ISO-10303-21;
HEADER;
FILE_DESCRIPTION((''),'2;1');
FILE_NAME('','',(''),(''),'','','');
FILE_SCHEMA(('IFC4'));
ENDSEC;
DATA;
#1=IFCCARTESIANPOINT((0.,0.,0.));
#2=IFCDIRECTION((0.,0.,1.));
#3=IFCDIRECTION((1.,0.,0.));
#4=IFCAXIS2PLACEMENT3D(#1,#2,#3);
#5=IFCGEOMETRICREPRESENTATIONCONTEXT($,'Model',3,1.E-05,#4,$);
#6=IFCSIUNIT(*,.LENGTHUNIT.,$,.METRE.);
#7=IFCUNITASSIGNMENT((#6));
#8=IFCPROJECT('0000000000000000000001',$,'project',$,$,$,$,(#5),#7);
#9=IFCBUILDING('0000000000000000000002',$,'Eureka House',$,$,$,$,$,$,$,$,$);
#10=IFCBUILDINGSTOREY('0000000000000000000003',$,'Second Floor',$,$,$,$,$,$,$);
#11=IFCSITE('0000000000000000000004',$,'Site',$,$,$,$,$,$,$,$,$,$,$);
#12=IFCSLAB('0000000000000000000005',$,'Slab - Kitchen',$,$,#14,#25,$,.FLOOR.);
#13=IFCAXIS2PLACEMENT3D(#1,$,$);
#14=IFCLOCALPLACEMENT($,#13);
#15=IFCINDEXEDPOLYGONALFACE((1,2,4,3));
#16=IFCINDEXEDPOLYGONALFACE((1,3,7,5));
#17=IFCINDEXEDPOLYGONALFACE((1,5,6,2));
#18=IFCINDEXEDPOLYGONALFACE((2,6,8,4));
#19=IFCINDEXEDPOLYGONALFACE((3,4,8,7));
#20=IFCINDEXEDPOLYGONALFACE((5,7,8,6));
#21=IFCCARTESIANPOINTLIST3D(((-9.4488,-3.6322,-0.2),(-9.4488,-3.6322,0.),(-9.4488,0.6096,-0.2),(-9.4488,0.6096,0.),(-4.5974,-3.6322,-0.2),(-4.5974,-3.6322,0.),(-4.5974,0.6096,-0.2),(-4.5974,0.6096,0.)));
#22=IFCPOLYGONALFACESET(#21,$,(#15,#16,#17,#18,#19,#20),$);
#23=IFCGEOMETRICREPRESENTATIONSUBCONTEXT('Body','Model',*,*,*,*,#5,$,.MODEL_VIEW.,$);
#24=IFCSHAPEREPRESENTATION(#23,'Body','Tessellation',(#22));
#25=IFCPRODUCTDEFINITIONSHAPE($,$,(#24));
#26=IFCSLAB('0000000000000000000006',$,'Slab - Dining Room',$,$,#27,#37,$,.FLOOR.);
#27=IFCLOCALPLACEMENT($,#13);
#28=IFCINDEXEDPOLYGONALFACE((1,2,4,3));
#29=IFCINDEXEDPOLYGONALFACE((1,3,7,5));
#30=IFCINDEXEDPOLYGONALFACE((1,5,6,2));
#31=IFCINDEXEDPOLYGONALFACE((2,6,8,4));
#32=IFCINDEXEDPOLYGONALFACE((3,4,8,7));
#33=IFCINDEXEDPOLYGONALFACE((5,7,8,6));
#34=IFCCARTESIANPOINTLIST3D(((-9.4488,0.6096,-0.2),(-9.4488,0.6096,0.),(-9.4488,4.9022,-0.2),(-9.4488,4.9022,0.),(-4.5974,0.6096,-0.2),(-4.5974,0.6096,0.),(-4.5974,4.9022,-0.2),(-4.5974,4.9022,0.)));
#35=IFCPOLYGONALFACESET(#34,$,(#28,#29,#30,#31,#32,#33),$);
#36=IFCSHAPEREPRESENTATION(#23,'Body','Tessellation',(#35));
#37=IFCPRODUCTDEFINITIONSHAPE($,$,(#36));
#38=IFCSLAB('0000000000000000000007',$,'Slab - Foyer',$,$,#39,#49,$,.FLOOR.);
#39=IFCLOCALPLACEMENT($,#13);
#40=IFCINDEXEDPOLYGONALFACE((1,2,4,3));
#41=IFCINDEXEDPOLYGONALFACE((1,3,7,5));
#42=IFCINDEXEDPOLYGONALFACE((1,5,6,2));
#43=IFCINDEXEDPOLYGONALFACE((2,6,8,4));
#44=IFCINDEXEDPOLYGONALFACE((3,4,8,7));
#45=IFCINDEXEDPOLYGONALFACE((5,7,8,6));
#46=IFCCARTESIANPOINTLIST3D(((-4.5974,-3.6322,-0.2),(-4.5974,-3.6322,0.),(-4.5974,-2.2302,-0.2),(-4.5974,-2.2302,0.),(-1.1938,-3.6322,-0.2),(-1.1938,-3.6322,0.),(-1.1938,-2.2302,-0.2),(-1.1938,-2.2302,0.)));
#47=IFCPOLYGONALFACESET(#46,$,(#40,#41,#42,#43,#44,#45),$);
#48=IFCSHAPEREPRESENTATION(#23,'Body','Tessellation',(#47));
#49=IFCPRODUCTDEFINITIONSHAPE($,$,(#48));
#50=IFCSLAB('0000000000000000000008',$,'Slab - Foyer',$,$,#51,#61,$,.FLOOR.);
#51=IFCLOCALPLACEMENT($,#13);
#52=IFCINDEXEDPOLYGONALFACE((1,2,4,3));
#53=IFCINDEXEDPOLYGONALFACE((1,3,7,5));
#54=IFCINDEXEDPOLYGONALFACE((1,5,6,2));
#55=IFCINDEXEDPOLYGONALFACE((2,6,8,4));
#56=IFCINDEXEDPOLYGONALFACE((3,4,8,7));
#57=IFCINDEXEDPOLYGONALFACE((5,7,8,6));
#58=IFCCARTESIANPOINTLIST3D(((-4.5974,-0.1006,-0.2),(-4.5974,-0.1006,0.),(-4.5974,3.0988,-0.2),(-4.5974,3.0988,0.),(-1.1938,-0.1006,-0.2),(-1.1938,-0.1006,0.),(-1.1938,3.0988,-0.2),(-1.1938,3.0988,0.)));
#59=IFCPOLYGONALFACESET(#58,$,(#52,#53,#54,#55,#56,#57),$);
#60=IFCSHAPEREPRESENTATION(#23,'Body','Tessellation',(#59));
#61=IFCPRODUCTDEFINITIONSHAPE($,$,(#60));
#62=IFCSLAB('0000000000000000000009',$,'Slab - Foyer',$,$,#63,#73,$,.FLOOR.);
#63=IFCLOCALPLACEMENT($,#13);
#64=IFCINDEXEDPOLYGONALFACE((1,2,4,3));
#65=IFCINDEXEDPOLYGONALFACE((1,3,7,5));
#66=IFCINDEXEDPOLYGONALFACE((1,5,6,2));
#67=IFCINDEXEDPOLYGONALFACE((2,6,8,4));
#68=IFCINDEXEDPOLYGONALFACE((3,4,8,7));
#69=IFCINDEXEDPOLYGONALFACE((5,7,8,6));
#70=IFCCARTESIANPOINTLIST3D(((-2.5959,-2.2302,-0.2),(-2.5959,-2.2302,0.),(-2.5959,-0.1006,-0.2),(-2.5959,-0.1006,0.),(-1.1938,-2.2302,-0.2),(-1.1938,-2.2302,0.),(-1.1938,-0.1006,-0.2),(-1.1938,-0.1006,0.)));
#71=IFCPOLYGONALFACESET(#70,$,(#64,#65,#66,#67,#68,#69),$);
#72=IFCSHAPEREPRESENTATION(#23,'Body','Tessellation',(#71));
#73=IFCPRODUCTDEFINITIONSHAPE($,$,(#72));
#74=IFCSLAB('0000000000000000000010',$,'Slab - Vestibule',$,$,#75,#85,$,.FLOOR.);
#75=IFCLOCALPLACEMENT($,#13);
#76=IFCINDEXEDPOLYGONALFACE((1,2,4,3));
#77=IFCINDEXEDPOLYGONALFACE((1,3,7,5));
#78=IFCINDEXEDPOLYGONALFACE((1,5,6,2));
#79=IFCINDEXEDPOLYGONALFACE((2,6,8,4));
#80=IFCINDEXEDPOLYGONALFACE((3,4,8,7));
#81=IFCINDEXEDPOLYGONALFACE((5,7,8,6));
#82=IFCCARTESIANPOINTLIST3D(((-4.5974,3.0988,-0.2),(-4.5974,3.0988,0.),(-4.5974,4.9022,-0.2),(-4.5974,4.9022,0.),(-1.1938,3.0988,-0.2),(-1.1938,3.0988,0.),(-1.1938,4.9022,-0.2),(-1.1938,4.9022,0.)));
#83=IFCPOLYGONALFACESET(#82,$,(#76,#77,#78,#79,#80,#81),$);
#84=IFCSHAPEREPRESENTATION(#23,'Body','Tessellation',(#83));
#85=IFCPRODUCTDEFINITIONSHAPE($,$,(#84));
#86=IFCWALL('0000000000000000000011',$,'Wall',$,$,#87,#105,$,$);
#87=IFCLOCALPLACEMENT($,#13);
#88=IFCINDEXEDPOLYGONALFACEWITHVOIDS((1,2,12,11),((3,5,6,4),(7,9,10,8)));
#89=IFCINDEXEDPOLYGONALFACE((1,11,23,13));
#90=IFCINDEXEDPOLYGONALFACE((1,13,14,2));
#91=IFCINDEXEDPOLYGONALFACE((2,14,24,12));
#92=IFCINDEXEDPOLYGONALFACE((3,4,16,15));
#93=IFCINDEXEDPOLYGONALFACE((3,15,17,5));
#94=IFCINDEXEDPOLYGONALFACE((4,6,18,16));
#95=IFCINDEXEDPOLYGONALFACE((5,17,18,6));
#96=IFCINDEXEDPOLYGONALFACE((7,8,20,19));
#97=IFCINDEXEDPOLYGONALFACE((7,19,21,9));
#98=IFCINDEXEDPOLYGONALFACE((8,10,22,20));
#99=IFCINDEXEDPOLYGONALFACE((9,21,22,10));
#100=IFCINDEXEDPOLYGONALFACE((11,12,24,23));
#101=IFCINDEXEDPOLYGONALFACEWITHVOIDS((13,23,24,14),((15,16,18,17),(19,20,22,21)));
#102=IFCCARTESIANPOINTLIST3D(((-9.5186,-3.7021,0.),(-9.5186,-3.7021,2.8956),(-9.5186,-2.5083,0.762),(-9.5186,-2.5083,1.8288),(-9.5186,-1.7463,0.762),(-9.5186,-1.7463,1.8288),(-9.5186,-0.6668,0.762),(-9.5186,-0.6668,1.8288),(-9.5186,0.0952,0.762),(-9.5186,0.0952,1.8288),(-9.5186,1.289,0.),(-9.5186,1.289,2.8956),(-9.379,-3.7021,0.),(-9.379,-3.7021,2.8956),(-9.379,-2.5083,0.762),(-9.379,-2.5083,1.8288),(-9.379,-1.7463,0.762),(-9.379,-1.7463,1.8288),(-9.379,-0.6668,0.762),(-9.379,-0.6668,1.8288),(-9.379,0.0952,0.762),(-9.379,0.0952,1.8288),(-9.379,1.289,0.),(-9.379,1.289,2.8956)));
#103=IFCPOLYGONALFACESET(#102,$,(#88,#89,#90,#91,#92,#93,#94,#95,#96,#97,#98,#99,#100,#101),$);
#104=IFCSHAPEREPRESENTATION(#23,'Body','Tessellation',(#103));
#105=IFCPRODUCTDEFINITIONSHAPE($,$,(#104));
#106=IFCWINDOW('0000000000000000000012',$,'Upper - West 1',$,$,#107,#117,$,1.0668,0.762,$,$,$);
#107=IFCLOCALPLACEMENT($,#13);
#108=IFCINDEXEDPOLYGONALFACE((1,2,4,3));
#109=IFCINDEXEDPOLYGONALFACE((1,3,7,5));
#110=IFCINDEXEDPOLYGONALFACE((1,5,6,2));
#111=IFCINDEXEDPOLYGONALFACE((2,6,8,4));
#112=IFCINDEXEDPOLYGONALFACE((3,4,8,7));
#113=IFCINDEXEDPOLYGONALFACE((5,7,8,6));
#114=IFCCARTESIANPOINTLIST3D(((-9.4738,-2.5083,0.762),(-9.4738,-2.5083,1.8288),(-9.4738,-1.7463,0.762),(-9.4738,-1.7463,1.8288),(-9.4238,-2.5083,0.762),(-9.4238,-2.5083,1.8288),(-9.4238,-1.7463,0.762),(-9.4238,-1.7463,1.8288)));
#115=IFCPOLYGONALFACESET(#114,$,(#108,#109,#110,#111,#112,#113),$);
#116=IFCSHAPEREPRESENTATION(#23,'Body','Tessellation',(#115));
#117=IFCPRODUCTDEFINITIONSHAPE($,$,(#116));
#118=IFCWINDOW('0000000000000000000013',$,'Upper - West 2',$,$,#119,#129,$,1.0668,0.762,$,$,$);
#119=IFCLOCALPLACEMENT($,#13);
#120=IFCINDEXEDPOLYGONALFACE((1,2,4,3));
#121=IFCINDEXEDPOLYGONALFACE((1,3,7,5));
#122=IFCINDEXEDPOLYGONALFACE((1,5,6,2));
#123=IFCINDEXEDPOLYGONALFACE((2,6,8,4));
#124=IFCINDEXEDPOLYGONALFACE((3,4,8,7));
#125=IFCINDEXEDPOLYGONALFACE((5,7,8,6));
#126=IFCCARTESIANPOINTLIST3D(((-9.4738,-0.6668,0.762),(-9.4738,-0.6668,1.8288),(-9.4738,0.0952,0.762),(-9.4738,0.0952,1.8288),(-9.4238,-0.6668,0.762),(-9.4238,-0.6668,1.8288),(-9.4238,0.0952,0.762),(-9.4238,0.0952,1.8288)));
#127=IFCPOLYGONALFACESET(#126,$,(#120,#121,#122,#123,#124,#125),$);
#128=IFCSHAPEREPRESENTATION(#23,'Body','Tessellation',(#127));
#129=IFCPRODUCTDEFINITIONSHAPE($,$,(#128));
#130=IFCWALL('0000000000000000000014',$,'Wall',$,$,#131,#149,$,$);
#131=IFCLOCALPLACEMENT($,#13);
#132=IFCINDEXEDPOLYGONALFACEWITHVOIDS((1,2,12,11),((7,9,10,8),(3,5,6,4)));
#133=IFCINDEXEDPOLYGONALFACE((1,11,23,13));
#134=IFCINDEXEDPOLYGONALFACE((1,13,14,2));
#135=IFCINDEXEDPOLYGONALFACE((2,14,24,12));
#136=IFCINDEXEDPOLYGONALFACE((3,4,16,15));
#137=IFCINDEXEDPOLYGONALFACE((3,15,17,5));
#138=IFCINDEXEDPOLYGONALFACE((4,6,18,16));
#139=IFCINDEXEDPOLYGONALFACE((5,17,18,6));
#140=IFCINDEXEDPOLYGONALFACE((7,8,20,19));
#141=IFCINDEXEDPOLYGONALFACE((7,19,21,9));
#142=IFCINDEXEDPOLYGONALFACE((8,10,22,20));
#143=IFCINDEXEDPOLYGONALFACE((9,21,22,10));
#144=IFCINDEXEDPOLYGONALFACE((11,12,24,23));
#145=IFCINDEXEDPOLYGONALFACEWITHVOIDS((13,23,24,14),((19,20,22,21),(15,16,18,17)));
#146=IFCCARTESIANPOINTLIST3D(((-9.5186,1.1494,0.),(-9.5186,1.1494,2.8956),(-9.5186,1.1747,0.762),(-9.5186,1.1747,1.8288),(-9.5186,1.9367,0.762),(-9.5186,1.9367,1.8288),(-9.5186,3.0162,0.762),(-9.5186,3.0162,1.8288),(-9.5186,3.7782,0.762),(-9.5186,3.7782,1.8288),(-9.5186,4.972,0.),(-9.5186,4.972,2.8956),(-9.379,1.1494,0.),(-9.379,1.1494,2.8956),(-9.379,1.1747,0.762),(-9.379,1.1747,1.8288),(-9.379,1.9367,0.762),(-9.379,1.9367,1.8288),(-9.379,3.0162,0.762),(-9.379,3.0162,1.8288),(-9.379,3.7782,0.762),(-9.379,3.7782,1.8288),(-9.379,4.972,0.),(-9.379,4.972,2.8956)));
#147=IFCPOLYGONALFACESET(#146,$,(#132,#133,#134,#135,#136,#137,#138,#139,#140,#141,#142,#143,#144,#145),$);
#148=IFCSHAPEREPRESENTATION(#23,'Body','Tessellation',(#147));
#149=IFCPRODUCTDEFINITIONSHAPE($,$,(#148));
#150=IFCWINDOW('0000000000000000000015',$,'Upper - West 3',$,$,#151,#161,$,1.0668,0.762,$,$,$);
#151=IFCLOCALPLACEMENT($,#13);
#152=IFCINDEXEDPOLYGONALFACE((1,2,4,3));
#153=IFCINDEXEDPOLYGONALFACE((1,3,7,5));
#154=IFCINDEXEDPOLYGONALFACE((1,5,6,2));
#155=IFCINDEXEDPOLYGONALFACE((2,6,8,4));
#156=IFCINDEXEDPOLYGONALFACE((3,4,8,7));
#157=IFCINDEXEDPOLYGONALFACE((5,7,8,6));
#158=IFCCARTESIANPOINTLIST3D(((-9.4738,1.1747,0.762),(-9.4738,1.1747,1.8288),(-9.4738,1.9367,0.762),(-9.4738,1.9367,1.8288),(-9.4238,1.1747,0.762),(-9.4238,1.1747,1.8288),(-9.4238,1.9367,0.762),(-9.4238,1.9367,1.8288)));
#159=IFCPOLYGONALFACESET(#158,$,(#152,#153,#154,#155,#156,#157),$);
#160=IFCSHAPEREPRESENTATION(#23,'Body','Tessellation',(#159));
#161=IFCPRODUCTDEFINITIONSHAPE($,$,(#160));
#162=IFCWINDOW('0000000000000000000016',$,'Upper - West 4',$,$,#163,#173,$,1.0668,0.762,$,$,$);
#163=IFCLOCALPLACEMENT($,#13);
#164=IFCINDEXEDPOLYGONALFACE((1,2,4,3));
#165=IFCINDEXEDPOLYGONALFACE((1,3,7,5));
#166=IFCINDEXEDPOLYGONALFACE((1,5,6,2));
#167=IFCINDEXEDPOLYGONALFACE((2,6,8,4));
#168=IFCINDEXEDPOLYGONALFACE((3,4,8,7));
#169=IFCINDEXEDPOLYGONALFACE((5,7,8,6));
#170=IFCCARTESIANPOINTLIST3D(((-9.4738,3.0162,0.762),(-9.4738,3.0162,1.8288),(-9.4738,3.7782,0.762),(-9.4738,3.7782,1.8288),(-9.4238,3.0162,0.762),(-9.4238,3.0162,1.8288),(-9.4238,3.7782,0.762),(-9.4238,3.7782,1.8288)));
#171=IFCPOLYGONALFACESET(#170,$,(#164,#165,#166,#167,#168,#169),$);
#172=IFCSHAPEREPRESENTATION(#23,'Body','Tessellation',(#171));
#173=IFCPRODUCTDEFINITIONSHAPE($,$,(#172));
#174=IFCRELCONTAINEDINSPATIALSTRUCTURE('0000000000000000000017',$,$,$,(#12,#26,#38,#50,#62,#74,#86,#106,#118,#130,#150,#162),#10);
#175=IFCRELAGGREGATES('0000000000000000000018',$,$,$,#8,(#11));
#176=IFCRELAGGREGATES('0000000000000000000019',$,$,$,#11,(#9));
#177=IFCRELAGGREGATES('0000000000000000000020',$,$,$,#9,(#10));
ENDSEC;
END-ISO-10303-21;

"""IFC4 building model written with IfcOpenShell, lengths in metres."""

from ifc_helpers import new_model, si_unit, frame, origin, origin_with_axes, origin_2d, place, context, subcontext, project, spatial, rectangle, extrude, element, fill, save


model = new_model("IFC4")

# Units and contexts
model_context = context("Model", 3, precision=1e-05, world=origin_with_axes())
body_context = subcontext(model_context, "Body", "Model", "MODEL_VIEW")
ifc_project = project(units=[si_unit("LENGTHUNIT", "METRE")], contexts=[model_context])

# Site, building, storey
site = spatial("IfcSite", under=ifc_project, Name="Site")
building = spatial("IfcBuilding", under=site, Name="Eureka House")
storey = spatial("IfcBuildingStorey", under=building, Name="Second Floor")

# Slabs
slab_1_placement = place(None, frame((-7.0231, -1.5113, -0.2), z_axis=(0.0, 0.0, 1.0), x_axis=(1.0, 0.0, 0.0)))
element("IfcSlab", 1, at=slab_1_placement, inside=storey, Name="Slab - Kitchen", PredefinedType="FLOOR", context=body_context, shape_type="SweptSolid", body=[
    extrude(rectangle(XDim=4.8514, YDim=4.2418, at=origin_2d()), origin(), (0.0, 0.0, 1.0), 0.2),
])
slab_2_placement = place(None, frame((-7.0231, 2.7559, -0.2), z_axis=(0.0, 0.0, 1.0), x_axis=(1.0, 0.0, 0.0)))
element("IfcSlab", 2, at=slab_2_placement, inside=storey, Name="Slab - Dining Room", PredefinedType="FLOOR", context=body_context, shape_type="SweptSolid", body=[
    extrude(rectangle(XDim=4.8514, YDim=4.2926, at=origin_2d()), origin(), (0.0, 0.0, 1.0), 0.2),
])
slab_3_placement = place(None, frame((-2.8956, -2.9312, -0.2), z_axis=(0.0, 0.0, 1.0), x_axis=(1.0, 0.0, 0.0)))
element("IfcSlab", 3, at=slab_3_placement, inside=storey, Name="Slab - Foyer", PredefinedType="FLOOR", context=body_context, shape_type="SweptSolid", body=[
    extrude(rectangle(XDim=3.4036, YDim=1.402, at=origin_2d()), origin(), (0.0, 0.0, 1.0), 0.2),
])
slab_4_placement = place(None, frame((-2.8956, 1.4991, -0.2), z_axis=(0.0, 0.0, 1.0), x_axis=(1.0, 0.0, 0.0)))
element("IfcSlab", 4, at=slab_4_placement, inside=storey, Name="Slab - Foyer", PredefinedType="FLOOR", context=body_context, shape_type="SweptSolid", body=[
    extrude(rectangle(XDim=3.4036, YDim=3.1994, at=origin_2d()), origin(), (0.0, 0.0, 1.0), 0.2),
])
slab_5_placement = place(None, frame((-1.8949, -1.1654, -0.2), z_axis=(0.0, 0.0, 1.0), x_axis=(1.0, 0.0, 0.0)))
element("IfcSlab", 5, at=slab_5_placement, inside=storey, Name="Slab - Foyer", PredefinedType="FLOOR", context=body_context, shape_type="SweptSolid", body=[
    extrude(rectangle(XDim=1.4021, YDim=2.1296, at=origin_2d()), origin(), (0.0, 0.0, 1.0), 0.2),
])
slab_6_placement = place(None, frame((-2.8956, 4.0005, -0.2), z_axis=(0.0, 0.0, 1.0), x_axis=(1.0, 0.0, 0.0)))
element("IfcSlab", 6, at=slab_6_placement, inside=storey, Name="Slab - Vestibule", PredefinedType="FLOOR", context=body_context, shape_type="SweptSolid", body=[
    extrude(rectangle(XDim=3.4036, YDim=1.8034, at=origin_2d()), origin(), (0.0, 0.0, 1.0), 0.2),
])

# Walls, openings, windows
wall_1_placement = place(None, frame((-9.4488, -1.2065, 0.0), z_axis=(0.0, 0.0, 1.0), x_axis=(1.0, 0.0, 0.0)))
wall_1 = element("IfcWall", 7, at=wall_1_placement, inside=storey, Name="Wall", context=body_context, shape_type="SweptSolid", body=[
    extrude(rectangle(XDim=0.1397, YDim=4.9911, at=origin_2d()), origin(), (0.0, 0.0, 1.0), 2.8956),
])
opening_1_placement = place(wall_1_placement, frame((0.0, -0.9208, 0.762), z_axis=(0.0, 0.0, 1.0), x_axis=(1.0, 0.0, 0.0)))
opening_1 = element("IfcOpeningElement", 8, at=opening_1_placement, cuts=wall_1, context=body_context, shape_type="SweptSolid", body=[
    extrude(rectangle(XDim=0.2397, YDim=0.762, at=origin_2d()), origin(), (0.0, 0.0, 1.0), 1.0668),
])
opening_2_placement = place(wall_1_placement, frame((0.0, 0.9207, 0.762), z_axis=(0.0, 0.0, 1.0), x_axis=(1.0, 0.0, 0.0)))
opening_2 = element("IfcOpeningElement", 9, at=opening_2_placement, cuts=wall_1, context=body_context, shape_type="SweptSolid", body=[
    extrude(rectangle(XDim=0.2397, YDim=0.762, at=origin_2d()), origin(), (0.0, 0.0, 1.0), 1.0668),
])
window_1_placement = place(opening_1_placement, origin_with_axes())
window_1 = element("IfcWindow", 10, at=window_1_placement, inside=storey, Name="Upper - West 1", OverallHeight=1.0668, OverallWidth=0.762, context=body_context, shape_type="SweptSolid", body=[
    extrude(rectangle(XDim=0.05, YDim=0.762, at=origin_2d()), origin(), (0.0, 0.0, 1.0), 1.0668),
])
fill(opening_1, window_1)
window_2_placement = place(opening_2_placement, frame((0.0, 0.0, 0.0), z_axis=(0.0, 0.0, 1.0), x_axis=(1.0, 0.0, 0.0)))
window_2 = element("IfcWindow", 11, at=window_2_placement, inside=storey, Name="Upper - West 2", OverallHeight=1.0668, OverallWidth=0.762, context=body_context, shape_type="SweptSolid", body=[
    extrude(rectangle(XDim=0.05, YDim=0.762, at=origin_2d()), origin(), (0.0, 0.0, 1.0), 1.0668),
])
fill(opening_2, window_2)
wall_2_placement = place(None, frame((-9.4488, 3.0607, 0.0), z_axis=(0.0, 0.0, 1.0), x_axis=(1.0, 0.0, 0.0)))
wall_2 = element("IfcWall", 12, at=wall_2_placement, inside=storey, Name="Wall", context=body_context, shape_type="SweptSolid", body=[
    extrude(rectangle(XDim=0.1397, YDim=3.8227, at=origin_2d()), origin(), (0.0, 0.0, 1.0), 2.8956),
])
opening_3_placement = place(wall_2_placement, frame((0.0, -1.505, 0.762), z_axis=(0.0, 0.0, 1.0), x_axis=(1.0, 0.0, 0.0)))
opening_3 = element("IfcOpeningElement", 13, at=opening_3_placement, cuts=wall_2, context=body_context, shape_type="SweptSolid", body=[
    extrude(rectangle(XDim=0.2397, YDim=0.762, at=origin_2d()), origin(), (0.0, 0.0, 1.0), 1.0668),
])
opening_4_placement = place(wall_2_placement, frame((0.0, 0.3365, 0.762), z_axis=(0.0, 0.0, 1.0), x_axis=(1.0, 0.0, 0.0)))
opening_4 = element("IfcOpeningElement", 14, at=opening_4_placement, cuts=wall_2, context=body_context, shape_type="SweptSolid", body=[
    extrude(rectangle(XDim=0.2397, YDim=0.762, at=origin_2d()), origin(), (0.0, 0.0, 1.0), 1.0668),
])
window_3_placement = place(opening_3_placement, origin_with_axes())
window_3 = element("IfcWindow", 15, at=window_3_placement, inside=storey, Name="Upper - West 3", OverallHeight=1.0668, OverallWidth=0.762, context=body_context, shape_type="SweptSolid", body=[
    extrude(rectangle(XDim=0.05, YDim=0.762, at=origin_2d()), origin(), (0.0, 0.0, 1.0), 1.0668),
])
fill(opening_3, window_3)
window_4_placement = place(opening_4_placement, origin_with_axes())
window_4 = element("IfcWindow", 16, at=window_4_placement, inside=storey, Name="Upper - West 4", OverallHeight=1.0668, OverallWidth=0.762, context=body_context, shape_type="SweptSolid", body=[
    extrude(rectangle(XDim=0.05, YDim=0.762, at=origin_2d()), origin(), (0.0, 0.0, 1.0), 1.0668),
])
fill(opening_4, window_4)

save(model, "model.ifc")
